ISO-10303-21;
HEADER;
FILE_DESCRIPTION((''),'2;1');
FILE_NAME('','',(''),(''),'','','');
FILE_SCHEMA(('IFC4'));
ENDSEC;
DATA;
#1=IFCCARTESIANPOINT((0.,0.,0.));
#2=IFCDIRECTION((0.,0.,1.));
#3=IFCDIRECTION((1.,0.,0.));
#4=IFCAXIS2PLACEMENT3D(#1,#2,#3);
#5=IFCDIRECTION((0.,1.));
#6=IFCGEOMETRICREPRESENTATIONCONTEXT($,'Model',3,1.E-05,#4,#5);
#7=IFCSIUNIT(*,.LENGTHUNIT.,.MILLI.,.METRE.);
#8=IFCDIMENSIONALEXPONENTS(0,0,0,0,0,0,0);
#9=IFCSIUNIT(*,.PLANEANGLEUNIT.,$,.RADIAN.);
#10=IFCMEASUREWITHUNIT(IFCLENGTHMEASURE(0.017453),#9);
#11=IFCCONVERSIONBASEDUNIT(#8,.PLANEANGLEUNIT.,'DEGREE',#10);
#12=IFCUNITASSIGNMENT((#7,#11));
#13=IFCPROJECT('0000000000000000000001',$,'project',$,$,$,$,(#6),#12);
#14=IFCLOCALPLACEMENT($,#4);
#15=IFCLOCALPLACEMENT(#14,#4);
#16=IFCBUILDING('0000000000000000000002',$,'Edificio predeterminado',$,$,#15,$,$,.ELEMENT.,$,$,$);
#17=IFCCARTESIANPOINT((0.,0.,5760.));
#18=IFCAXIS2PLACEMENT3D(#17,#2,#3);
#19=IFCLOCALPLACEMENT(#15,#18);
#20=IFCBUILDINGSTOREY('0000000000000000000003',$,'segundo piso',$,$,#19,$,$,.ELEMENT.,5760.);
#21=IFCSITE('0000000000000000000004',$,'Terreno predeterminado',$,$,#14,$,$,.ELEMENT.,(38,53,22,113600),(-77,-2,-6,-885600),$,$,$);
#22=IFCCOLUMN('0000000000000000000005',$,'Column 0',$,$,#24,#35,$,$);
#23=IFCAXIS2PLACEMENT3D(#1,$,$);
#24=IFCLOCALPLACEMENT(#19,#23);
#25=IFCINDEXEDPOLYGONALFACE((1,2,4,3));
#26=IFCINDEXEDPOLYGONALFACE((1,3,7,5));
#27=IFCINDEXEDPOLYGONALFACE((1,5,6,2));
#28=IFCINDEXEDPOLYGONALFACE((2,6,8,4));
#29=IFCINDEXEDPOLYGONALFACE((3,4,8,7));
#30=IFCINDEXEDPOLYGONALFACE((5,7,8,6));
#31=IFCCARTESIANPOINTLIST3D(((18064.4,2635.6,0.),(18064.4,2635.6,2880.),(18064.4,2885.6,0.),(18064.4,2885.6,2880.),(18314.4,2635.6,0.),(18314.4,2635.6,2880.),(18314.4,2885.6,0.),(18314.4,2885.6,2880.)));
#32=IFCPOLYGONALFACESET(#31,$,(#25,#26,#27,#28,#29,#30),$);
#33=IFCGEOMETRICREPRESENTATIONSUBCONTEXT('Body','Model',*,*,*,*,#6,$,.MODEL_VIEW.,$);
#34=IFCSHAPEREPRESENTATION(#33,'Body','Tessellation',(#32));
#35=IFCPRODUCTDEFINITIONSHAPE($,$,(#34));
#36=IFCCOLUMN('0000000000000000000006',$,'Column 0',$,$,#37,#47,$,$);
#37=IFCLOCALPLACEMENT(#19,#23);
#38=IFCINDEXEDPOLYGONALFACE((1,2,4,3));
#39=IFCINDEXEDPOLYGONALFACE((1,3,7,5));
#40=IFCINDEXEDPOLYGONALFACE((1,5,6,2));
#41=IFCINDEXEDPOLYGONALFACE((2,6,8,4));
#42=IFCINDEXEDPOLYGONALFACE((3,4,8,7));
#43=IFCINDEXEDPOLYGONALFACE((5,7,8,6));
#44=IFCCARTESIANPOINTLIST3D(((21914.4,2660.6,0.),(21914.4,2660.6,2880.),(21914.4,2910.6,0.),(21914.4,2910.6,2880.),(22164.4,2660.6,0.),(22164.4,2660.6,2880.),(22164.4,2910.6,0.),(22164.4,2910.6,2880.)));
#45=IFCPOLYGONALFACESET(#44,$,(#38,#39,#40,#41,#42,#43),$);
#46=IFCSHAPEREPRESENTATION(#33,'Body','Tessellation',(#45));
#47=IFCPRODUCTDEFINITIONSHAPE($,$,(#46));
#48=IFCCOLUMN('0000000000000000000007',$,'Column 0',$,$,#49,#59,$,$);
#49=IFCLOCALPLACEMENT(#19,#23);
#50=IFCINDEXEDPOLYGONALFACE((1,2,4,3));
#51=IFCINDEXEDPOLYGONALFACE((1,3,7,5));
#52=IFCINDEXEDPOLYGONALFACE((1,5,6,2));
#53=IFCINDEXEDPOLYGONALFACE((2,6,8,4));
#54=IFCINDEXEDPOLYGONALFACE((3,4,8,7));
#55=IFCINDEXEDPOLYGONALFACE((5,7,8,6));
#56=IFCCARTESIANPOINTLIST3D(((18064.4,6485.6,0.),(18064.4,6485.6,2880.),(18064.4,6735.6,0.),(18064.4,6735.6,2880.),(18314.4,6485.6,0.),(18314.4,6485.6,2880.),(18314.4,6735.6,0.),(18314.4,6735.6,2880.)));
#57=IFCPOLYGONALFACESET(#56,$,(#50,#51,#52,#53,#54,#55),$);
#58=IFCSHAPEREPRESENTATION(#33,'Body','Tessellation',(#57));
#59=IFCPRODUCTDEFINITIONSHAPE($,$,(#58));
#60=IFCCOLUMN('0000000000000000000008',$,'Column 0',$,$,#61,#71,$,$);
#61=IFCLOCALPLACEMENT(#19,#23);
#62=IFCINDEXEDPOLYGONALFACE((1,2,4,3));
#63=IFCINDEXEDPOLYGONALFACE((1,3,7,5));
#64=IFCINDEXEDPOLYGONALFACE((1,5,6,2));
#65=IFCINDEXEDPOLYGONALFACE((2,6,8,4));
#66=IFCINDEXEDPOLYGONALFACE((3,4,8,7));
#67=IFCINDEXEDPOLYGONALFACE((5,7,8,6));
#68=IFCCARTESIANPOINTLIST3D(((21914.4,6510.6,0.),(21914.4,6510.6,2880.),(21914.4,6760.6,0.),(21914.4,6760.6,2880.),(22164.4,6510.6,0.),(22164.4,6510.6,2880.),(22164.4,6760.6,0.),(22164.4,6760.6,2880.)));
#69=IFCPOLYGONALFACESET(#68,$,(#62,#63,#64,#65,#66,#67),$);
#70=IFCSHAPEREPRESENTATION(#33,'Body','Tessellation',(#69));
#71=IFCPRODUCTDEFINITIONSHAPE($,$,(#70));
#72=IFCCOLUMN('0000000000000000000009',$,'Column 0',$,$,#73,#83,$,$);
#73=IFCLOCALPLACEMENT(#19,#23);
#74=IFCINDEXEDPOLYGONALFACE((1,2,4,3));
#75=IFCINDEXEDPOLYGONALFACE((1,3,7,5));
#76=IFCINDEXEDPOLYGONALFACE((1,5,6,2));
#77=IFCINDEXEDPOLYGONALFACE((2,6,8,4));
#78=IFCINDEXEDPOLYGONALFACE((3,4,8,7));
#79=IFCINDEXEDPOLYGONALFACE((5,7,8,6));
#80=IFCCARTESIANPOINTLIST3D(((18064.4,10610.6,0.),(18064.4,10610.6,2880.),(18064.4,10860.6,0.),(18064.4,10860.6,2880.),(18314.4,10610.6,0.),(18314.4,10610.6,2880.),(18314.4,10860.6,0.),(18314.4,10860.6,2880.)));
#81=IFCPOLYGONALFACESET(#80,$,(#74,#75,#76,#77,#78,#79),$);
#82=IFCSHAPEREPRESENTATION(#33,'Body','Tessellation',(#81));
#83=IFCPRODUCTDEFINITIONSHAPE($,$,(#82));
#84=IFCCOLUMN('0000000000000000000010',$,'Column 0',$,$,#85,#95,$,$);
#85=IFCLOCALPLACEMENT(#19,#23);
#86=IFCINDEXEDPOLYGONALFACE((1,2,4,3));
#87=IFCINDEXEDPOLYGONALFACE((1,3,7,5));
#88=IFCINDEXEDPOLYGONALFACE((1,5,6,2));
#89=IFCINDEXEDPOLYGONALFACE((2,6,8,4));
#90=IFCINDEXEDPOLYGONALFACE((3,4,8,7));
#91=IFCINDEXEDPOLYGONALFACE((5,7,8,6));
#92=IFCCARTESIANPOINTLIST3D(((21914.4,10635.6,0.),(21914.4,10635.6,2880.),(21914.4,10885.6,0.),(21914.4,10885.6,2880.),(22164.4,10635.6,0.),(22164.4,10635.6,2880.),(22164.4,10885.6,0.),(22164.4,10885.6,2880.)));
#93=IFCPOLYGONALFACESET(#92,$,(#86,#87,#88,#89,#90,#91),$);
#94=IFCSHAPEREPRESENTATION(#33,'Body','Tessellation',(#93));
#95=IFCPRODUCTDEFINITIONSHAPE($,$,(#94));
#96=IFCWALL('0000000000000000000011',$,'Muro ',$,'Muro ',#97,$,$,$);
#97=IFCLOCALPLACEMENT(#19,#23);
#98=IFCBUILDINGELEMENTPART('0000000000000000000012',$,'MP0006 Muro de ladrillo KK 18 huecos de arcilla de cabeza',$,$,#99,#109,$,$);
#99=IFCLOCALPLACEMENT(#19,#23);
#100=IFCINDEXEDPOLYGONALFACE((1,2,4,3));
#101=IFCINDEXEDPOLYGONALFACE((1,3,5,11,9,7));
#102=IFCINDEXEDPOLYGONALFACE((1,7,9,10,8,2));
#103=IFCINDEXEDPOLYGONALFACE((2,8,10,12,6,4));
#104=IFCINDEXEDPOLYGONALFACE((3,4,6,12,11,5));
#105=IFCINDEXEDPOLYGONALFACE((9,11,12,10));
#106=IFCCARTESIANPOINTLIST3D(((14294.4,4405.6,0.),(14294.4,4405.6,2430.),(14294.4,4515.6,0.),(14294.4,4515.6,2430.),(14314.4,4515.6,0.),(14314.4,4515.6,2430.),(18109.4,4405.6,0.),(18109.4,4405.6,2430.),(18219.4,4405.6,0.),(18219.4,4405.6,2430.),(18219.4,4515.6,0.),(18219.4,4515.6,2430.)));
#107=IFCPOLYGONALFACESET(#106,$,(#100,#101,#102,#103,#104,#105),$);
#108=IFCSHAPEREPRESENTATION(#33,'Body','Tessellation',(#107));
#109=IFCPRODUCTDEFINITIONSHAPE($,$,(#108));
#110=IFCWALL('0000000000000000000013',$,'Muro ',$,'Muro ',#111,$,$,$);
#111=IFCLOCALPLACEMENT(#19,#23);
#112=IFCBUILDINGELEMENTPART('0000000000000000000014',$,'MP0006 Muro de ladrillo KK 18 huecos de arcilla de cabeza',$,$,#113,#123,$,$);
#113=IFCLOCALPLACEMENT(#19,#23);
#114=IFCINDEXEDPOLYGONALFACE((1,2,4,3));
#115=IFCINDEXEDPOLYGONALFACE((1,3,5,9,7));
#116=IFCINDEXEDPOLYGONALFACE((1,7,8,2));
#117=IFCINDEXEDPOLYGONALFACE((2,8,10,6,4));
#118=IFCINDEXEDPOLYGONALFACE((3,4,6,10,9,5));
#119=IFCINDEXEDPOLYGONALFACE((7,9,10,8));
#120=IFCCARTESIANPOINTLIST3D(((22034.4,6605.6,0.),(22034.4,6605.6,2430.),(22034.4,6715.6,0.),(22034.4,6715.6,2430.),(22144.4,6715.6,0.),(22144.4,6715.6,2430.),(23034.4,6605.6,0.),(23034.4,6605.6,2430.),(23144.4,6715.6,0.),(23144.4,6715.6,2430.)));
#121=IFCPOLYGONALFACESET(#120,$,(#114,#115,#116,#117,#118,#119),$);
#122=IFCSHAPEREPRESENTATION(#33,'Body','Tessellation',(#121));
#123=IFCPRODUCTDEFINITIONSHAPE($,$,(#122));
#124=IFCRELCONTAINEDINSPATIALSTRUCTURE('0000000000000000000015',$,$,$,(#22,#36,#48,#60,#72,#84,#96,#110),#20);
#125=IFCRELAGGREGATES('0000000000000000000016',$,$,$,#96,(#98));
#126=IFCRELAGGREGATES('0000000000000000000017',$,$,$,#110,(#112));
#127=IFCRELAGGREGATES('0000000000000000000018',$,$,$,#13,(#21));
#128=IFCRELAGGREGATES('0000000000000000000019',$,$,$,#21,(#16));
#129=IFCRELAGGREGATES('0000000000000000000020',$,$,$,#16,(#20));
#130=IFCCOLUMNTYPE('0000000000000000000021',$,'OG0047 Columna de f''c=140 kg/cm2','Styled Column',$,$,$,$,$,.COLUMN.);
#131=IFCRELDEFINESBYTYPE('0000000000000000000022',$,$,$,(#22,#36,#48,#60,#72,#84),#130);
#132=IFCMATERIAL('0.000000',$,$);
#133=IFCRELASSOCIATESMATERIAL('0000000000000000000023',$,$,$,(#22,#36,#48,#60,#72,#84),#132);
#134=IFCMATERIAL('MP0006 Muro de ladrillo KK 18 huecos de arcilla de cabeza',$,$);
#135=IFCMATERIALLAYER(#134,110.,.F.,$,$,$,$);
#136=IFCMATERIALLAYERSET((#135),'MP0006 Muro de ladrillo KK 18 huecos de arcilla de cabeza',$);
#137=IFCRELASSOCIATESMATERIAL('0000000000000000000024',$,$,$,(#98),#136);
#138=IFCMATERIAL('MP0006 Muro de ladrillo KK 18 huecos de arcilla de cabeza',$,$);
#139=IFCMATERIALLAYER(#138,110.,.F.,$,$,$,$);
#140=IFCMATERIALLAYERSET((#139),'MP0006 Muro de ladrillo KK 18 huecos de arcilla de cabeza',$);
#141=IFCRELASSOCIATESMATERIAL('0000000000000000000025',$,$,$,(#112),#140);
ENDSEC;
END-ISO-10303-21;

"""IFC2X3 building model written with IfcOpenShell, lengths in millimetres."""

from ifc_helpers import new_model, entity, si_unit, converted_unit, direction, frame, origin_with_axes, place, context, subcontext, project, spatial, polyline, outline, extrude, material, layer, layer_set, layer_usage, type_object, element, aggregate, save


model = new_model("IFC2X3")

# Units and contexts
model_context = context("Model", 3, precision=1e-05, world=origin_with_axes(), true_north=direction((0.0, 1.0)))
body_context = subcontext(model_context, "Body", "Model", "MODEL_VIEW")
ifc_project = project(units=[si_unit("LENGTHUNIT", "METRE", prefix="MILLI"), converted_unit("PLANEANGLEUNIT", "DEGREE", entity("IfcLengthMeasure", 0.017453), si_unit("PLANEANGLEUNIT", "RADIAN"), dimensions=[0, 0, 0, 0, 0, 0, 0])], contexts=[model_context])

# Site, building, storey
site_placement = place(None, origin_with_axes())
site = spatial("IfcSite", under=ifc_project, at=site_placement, Name="Terreno predeterminado", CompositionType="ELEMENT", RefLatitude=(38, 53, 22, 113600), RefLongitude=(-77, -2, -6, -885600))
building_placement = place(site_placement, origin_with_axes())
building = spatial("IfcBuilding", under=site, at=building_placement, Name="Edificio predeterminado", CompositionType="ELEMENT")
storey_placement = place(building_placement, frame((0.0, 0.0, 5760.0), z_axis=(0.0, 0.0, 1.0), x_axis=(1.0, 0.0, 0.0)))
storey = spatial("IfcBuildingStorey", under=building, at=storey_placement, Name="segundo piso", CompositionType="ELEMENT", Elevation=5760.0)

# Columns
ifc_material_1 = material(Name="0.000000")
column_type = type_object("IfcColumnType", Name="OG0047 Columna de f'c=140 kg/cm2", Description="Styled Column", PredefinedType="COLUMN")
for number, where, z_axis, x_axis, name in (
    (1, (18189.4, 2760.6, 0.0), (0.0, 0.0, 1.0), (1.0, 0.0, 0.0), "Column 0"),
    (2, (22039.4, 2785.6, 0.0), (0.0, 0.0, 1.0), (1.0, 0.0, 0.0), "Column 0"),
    (3, (18189.4, 6610.6, 0.0), (0.0, 0.0, 1.0), (1.0, 0.0, 0.0), "Column 0"),
    (4, (22039.4, 6635.6, 0.0), (0.0, 0.0, 1.0), (1.0, 0.0, 0.0), "Column 0"),
    (5, (18189.4, 10735.6, 0.0), (0.0, 0.0, 1.0), (1.0, 0.0, 0.0), "Column 0"),
    (6, (22039.4, 10760.6, 0.0), (0.0, 0.0, 1.0), (1.0, 0.0, 0.0), "Column 0"),
):
    element("IfcColumn", number, at=place(storey_placement, frame(where, z_axis=z_axis, x_axis=x_axis)), inside=storey, type_object=column_type, material=ifc_material_1, Name=name, context=body_context, shape_type="SweptSolid", body=[
        extrude(outline(polyline([(-125.0, -125.0), (125.0, -125.0), (125.0, 125.0), (-125.0, 125.0), (-125.0, -125.0)])), origin_with_axes(), (0.0, 0.0, 1.0), 2880.0),
    ])

# Walls, building element parts
wall_1_placement = place(storey_placement, frame((18164.4, 4460.6, 0.0), z_axis=(0.0, 0.0, 1.0), x_axis=(-1.0, 0.0, 0.0)))
wall_1 = element("IfcWall", 7, at=wall_1_placement, inside=storey, Name="Muro ", ObjectType="Muro ")
ifc_material_2 = material(Name="MP0006 Muro de ladrillo KK 18 huecos de arcilla de cabeza")
ifc_layer_1 = layer(ifc_material_2, 110.0, ventilated=False)
ifc_layer_set_1 = layer_set([ifc_layer_1], Name="MP0006 Muro de ladrillo KK 18 huecos de arcilla de cabeza")
ifc_layer_usage_1 = layer_usage(ifc_layer_set_1, "AXIS2", "NEGATIVE", -55.0)
building_element_part_1_placement = place(wall_1_placement, origin_with_axes())
building_element_part_1 = element("IfcBuildingElementPart", 8, at=building_element_part_1_placement, material=ifc_layer_usage_1, Name="MP0006 Muro de ladrillo KK 18 huecos de arcilla de cabeza", context=body_context, shape_type="SweptSolid", body=[
    extrude(outline(polyline([(3870.0, 55.0), (3870.0, -55.0), (3850.0, -55.0), (-55.0, -55.0), (-55.0, 55.0), (55.0, 55.0), (3870.0, 55.0)])), origin_with_axes(), (0.0, 0.0, 1.0), 2430.0),
])
aggregate(wall_1, [building_element_part_1])
wall_2_placement = place(storey_placement, frame((22089.4, 6660.6, 0.0), z_axis=(0.0, 0.0, 1.0), x_axis=(1.0, 0.0, 0.0)))
wall_2 = element("IfcWall", 9, at=wall_2_placement, inside=storey, Name="Muro ", ObjectType="Muro ")
ifc_material_3 = material(Name="MP0006 Muro de ladrillo KK 18 huecos de arcilla de cabeza")
ifc_layer_2 = layer(ifc_material_3, 110.0, ventilated=False)
ifc_layer_set_2 = layer_set([ifc_layer_2], Name="MP0006 Muro de ladrillo KK 18 huecos de arcilla de cabeza")
ifc_layer_usage_2 = layer_usage(ifc_layer_set_2, "AXIS2", "NEGATIVE", -55.0)
building_element_part_2_placement = place(wall_2_placement, origin_with_axes())
building_element_part_2 = element("IfcBuildingElementPart", 10, at=building_element_part_2_placement, material=ifc_layer_usage_2, Name="MP0006 Muro de ladrillo KK 18 huecos de arcilla de cabeza", context=body_context, shape_type="SweptSolid", body=[
    extrude(outline(polyline([(1055.0, 55.0), (945.0, -55.0), (-55.0, -55.0), (-55.0, 55.0), (55.0, 55.0), (1055.0, 55.0)])), origin_with_axes(), (0.0, 0.0, 1.0), 2430.0),
])
aggregate(wall_2, [building_element_part_2])

save(model, "model.ifc")
